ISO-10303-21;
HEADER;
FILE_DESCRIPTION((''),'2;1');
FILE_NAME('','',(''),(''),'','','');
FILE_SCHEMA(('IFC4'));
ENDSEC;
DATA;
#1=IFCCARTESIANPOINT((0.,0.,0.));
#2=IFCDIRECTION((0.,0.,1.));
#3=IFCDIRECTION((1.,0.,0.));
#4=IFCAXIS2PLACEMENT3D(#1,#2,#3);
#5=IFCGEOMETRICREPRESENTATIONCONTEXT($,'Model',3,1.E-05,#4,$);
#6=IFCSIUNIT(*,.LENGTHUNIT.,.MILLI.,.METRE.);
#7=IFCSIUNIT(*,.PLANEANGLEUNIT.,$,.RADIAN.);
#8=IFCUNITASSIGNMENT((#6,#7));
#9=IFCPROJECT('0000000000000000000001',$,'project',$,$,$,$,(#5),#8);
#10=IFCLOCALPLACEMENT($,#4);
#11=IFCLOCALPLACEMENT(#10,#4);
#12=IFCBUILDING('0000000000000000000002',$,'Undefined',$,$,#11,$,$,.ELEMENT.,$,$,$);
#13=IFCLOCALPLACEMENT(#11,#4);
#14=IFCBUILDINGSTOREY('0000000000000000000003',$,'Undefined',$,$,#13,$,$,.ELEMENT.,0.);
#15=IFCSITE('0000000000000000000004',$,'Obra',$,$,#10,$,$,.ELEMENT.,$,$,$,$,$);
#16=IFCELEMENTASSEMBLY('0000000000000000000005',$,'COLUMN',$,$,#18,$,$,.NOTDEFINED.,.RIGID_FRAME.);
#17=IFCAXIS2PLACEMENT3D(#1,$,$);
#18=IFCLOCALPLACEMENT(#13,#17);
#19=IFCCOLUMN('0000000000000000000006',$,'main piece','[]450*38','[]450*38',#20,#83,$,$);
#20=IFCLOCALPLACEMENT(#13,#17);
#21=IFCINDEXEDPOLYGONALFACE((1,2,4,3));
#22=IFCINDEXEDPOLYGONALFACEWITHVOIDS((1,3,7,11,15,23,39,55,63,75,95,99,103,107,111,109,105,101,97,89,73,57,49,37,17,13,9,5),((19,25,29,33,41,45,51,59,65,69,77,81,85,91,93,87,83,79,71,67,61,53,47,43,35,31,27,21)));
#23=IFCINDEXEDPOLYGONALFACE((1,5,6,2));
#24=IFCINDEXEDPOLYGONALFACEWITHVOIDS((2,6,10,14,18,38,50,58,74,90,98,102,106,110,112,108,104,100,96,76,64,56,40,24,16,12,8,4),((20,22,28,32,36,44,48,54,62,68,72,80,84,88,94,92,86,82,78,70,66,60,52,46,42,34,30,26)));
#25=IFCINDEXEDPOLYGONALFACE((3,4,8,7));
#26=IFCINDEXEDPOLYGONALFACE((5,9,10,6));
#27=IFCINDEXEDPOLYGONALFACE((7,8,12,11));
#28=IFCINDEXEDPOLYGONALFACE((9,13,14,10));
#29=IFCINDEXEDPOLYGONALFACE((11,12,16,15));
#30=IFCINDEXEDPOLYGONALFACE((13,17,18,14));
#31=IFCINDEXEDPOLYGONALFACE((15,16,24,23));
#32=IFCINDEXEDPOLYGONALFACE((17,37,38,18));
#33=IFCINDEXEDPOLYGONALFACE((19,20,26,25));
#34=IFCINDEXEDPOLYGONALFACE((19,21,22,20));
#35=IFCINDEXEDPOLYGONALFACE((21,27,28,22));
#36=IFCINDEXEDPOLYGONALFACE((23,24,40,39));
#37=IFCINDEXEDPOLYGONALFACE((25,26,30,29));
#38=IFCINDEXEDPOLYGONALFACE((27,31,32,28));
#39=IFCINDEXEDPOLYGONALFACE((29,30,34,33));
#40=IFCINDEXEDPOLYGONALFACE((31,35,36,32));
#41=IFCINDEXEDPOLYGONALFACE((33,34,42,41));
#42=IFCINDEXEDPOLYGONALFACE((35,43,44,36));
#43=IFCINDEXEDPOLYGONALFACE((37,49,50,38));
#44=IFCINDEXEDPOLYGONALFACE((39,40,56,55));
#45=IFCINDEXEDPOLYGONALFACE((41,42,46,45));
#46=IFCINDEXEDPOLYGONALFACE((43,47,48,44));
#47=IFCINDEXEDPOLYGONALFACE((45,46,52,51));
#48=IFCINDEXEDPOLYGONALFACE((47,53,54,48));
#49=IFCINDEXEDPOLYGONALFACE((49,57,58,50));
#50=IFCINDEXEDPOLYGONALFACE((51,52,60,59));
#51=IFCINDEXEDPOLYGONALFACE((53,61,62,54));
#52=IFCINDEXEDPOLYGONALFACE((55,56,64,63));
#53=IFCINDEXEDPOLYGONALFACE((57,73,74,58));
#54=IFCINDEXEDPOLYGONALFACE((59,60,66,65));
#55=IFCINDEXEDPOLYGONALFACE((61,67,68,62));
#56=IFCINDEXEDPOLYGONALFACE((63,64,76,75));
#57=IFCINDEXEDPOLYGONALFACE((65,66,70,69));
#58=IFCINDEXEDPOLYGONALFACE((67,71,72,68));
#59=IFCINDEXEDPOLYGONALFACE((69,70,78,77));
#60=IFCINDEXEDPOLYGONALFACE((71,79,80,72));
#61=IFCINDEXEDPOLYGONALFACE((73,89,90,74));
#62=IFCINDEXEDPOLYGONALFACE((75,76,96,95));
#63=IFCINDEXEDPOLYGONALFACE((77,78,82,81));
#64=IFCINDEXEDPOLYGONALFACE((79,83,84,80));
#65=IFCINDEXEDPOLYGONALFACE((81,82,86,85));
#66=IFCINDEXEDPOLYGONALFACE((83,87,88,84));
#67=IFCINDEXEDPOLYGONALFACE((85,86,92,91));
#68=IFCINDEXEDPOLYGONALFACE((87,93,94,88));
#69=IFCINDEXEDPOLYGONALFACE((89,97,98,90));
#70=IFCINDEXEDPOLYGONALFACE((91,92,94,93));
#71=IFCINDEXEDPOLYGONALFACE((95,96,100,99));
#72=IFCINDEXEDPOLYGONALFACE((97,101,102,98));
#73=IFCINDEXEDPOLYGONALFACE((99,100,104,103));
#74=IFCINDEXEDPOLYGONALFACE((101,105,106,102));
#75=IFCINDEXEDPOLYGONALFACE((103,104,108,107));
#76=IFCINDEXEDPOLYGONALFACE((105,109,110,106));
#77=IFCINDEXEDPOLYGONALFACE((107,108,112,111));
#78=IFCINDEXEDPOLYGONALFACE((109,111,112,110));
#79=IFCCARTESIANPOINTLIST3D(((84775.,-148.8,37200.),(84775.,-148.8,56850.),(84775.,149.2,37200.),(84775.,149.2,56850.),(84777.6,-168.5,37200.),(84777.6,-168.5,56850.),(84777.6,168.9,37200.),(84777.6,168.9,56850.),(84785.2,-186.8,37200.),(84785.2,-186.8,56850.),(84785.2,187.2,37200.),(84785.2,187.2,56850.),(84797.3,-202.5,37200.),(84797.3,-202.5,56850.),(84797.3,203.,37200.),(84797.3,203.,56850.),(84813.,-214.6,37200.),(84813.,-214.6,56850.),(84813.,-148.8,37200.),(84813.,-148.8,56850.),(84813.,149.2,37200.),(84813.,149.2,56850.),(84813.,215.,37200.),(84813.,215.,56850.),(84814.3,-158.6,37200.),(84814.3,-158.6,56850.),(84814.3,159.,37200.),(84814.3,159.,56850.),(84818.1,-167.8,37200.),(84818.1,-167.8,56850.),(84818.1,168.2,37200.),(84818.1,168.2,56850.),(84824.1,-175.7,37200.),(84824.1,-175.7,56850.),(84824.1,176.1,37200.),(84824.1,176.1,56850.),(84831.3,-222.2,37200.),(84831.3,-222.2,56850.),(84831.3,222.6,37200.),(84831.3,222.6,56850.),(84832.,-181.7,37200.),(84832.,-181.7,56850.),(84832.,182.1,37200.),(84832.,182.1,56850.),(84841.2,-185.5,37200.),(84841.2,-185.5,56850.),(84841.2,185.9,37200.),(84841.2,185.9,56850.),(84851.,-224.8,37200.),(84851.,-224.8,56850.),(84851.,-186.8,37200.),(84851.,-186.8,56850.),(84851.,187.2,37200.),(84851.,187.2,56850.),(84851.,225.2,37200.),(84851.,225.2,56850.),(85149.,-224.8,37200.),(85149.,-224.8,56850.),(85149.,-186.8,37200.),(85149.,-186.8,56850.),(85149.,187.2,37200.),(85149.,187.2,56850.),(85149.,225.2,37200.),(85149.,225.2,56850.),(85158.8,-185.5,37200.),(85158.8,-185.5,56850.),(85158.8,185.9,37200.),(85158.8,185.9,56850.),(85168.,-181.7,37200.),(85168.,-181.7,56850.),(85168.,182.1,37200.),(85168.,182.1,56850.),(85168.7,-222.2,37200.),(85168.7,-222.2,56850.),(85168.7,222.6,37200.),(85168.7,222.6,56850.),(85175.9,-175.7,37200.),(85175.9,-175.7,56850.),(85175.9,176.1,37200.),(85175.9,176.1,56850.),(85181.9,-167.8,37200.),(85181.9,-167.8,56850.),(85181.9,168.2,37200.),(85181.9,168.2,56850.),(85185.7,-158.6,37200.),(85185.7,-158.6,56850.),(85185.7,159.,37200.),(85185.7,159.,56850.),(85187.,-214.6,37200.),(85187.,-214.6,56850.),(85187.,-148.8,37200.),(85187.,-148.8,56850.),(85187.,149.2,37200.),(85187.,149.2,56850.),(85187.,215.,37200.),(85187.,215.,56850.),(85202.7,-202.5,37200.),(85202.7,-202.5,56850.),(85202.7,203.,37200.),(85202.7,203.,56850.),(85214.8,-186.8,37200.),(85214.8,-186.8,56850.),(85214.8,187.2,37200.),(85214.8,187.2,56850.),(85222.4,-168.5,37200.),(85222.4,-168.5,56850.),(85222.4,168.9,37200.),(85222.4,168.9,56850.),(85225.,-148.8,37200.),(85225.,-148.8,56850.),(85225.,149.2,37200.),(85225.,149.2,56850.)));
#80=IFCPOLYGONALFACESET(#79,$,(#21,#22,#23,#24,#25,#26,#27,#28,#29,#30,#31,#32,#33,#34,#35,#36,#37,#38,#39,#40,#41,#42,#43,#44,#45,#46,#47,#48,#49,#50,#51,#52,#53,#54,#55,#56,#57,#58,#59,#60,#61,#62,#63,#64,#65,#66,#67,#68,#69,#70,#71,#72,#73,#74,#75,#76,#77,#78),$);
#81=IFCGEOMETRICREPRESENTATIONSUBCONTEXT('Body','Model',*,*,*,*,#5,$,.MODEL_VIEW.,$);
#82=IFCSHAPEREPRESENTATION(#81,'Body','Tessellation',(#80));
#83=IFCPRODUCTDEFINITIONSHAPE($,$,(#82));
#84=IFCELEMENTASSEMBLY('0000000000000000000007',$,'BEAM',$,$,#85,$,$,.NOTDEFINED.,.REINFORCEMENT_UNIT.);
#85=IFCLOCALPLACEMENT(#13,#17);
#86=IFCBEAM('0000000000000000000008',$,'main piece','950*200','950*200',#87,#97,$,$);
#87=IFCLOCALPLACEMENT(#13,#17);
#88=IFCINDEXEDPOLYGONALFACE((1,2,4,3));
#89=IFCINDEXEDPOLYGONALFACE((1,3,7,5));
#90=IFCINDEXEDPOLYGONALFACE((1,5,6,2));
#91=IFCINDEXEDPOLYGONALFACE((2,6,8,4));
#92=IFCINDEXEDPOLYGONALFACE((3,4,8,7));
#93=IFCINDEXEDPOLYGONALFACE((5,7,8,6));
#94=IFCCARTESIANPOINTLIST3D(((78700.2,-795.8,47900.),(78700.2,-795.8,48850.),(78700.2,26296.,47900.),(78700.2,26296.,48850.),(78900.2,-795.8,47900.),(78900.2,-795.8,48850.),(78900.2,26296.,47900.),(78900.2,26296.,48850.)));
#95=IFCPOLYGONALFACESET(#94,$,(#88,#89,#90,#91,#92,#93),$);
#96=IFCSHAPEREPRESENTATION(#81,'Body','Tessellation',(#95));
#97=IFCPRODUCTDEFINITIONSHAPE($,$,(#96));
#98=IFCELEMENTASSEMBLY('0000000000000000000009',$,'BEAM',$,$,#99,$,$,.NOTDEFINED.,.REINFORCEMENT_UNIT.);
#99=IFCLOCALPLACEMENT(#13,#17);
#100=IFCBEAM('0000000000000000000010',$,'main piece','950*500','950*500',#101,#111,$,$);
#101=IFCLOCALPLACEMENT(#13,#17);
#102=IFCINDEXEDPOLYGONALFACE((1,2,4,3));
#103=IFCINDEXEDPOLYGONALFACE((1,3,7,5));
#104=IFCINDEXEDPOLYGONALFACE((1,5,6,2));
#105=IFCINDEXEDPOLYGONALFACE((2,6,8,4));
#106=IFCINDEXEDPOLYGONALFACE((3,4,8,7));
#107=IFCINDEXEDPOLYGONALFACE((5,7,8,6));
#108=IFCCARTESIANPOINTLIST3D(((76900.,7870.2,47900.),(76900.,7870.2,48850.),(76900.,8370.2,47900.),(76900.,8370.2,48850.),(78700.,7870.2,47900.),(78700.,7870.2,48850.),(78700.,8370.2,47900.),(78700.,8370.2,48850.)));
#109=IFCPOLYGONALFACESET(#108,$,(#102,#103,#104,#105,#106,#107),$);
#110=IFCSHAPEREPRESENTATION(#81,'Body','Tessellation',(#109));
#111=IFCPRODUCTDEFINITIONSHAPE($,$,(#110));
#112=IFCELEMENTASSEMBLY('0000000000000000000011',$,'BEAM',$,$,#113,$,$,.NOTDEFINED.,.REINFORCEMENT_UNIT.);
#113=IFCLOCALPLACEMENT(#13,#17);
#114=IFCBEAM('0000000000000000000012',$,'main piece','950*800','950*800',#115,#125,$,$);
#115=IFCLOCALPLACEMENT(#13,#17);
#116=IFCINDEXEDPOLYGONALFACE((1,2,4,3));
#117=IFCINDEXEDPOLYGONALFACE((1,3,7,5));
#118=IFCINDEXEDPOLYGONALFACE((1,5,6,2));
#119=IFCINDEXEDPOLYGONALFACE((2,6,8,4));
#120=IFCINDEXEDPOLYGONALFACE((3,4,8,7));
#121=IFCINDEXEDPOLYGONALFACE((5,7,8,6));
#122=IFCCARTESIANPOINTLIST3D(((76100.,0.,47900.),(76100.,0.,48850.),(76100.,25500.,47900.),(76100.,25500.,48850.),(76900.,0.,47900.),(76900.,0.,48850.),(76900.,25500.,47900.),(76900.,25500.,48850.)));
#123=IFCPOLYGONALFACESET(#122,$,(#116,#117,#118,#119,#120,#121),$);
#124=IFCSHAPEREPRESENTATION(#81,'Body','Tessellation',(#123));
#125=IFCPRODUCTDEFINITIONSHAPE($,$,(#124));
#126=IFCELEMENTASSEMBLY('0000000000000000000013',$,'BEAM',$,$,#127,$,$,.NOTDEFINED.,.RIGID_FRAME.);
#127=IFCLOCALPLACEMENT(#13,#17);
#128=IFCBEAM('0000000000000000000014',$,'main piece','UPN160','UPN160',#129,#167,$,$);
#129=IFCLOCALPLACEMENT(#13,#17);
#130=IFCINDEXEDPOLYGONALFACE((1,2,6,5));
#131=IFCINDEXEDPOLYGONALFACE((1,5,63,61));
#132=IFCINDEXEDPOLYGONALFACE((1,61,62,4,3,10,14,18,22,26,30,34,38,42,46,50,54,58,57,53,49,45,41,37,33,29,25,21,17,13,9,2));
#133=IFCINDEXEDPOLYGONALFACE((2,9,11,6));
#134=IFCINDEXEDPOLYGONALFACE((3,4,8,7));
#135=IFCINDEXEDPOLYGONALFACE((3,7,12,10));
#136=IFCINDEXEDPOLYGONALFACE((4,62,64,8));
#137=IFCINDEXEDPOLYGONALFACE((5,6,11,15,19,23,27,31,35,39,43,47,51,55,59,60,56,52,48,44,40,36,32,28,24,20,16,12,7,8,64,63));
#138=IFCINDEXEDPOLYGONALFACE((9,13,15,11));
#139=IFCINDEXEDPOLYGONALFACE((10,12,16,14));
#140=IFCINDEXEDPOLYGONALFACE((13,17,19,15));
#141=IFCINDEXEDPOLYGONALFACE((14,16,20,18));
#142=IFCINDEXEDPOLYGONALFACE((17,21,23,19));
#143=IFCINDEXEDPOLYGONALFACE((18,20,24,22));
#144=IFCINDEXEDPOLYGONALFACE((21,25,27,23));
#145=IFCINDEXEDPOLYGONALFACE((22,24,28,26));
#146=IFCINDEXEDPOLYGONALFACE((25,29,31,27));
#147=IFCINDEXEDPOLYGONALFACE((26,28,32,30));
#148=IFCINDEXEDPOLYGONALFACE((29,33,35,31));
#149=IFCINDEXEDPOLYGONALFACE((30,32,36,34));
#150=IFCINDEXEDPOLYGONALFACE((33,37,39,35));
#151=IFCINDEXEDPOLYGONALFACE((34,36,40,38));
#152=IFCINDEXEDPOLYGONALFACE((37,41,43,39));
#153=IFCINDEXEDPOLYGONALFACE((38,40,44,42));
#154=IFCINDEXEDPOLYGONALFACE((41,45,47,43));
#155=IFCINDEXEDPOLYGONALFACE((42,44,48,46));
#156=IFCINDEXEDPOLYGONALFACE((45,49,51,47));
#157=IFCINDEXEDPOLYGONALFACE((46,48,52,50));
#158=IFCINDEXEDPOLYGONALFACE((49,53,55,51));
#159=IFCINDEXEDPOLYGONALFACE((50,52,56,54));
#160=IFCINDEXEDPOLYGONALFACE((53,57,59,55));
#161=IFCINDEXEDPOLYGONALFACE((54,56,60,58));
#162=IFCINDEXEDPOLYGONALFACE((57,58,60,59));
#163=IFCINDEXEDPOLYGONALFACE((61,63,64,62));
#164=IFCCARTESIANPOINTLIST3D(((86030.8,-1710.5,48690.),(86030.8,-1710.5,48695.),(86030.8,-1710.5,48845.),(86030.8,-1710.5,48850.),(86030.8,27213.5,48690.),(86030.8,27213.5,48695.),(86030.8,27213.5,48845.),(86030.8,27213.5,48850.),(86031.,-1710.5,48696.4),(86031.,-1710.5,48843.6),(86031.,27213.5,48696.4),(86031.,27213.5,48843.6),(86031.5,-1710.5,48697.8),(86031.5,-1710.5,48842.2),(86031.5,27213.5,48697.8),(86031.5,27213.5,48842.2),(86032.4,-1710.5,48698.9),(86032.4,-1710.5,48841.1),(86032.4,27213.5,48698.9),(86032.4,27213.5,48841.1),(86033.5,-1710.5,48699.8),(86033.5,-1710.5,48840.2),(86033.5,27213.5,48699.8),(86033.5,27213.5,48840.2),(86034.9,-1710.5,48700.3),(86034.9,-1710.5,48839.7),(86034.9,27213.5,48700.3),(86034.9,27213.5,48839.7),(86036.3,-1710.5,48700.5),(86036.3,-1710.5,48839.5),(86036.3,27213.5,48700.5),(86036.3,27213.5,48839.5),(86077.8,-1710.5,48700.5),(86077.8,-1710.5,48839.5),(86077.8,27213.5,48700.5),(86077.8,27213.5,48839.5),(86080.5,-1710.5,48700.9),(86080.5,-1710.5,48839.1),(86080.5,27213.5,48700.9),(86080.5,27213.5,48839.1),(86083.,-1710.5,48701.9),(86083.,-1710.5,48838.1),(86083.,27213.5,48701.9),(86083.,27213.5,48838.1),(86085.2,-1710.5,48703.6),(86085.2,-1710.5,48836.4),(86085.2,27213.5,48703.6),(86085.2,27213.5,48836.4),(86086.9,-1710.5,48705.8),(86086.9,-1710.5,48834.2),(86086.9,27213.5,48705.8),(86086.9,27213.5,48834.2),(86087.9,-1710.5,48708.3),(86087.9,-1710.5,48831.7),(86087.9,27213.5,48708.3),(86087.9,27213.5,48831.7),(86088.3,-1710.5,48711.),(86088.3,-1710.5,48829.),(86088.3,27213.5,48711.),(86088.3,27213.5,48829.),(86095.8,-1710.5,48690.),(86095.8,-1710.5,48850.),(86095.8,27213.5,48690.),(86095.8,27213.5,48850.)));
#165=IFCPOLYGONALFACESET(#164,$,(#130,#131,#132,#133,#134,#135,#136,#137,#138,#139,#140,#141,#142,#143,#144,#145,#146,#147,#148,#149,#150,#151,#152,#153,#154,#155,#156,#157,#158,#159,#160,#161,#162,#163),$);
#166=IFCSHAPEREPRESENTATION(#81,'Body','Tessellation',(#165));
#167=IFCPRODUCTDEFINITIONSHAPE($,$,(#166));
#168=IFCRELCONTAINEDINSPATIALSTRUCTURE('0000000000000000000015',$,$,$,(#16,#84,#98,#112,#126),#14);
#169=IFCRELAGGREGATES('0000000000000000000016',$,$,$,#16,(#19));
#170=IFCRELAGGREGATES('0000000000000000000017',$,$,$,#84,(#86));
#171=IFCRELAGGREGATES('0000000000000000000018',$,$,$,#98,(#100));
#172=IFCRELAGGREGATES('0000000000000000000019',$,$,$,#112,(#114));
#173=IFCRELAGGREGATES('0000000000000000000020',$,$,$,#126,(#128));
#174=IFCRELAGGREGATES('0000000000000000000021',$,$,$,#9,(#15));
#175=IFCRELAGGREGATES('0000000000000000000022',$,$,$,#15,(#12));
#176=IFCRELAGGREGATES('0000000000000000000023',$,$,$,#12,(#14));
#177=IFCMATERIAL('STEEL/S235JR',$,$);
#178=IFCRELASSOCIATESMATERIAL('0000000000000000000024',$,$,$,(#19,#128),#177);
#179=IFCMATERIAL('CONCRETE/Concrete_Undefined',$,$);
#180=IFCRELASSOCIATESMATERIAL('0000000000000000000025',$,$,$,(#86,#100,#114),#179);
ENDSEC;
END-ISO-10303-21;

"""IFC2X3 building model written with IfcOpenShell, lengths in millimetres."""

from ifc_helpers import new_model, si_unit, frame, origin_with_axes, origin_2d_with_axis, place, context, subcontext, project, spatial, rectangle, hollow_rectangle, u_section, extrude, material, element, aggregate, save


model = new_model("IFC2X3")

# Units and contexts
model_context = context("Model", 3, precision=1e-05, world=origin_with_axes())
body_context = subcontext(model_context, "Body", "Model", "MODEL_VIEW")
ifc_project = project(units=[si_unit("LENGTHUNIT", "METRE", prefix="MILLI"), si_unit("PLANEANGLEUNIT", "RADIAN")], contexts=[model_context])

# Site, building, storey
site_placement = place(None, origin_with_axes())
site = spatial("IfcSite", under=ifc_project, at=site_placement, Name="Obra", CompositionType="ELEMENT")
building_placement = place(site_placement, origin_with_axes())
building = spatial("IfcBuilding", under=site, at=building_placement, Name="Undefined", CompositionType="ELEMENT")
storey_placement = place(building_placement, origin_with_axes())
storey = spatial("IfcBuildingStorey", under=building, at=storey_placement, Name="Undefined", CompositionType="ELEMENT", Elevation=0.0)

# Element assembly, column
ifc_material_1 = material(Name="STEEL/S235JR")
assembly_1_placement = place(storey_placement, origin_with_axes())
assembly_1 = element("IfcElementAssembly", 1, at=assembly_1_placement, inside=storey, Name="COLUMN", AssemblyPlace="NOTDEFINED", PredefinedType="RIGID_FRAME")
column_1_placement = place(assembly_1_placement, frame((85000.0, 0.2, 37200.0), z_axis=(0.0, 0.0, 1.0), x_axis=(0.0, 1.0, 0.0)))
column_1 = element("IfcColumn", 2, at=column_1_placement, material=ifc_material_1, Name="main piece", Description="[]450*38", ObjectType="[]450*38", context=body_context, shape_type="SweptSolid", body=[
    extrude(hollow_rectangle(XDim=450.0, YDim=450.0, WallThickness=38.0, InnerFilletRadius=38.0, OuterFilletRadius=76.0, at=origin_2d_with_axis()), frame((0.0, 0.0, 19650.0), z_axis=(0.0, 0.0, -1.0), x_axis=(0.0, 1.0, 0.0)), (0.0, 0.0, 1.0), 19650.0),
])
aggregate(assembly_1, [column_1])

# Element assemblies, beams
assembly_2_placement = place(storey_placement, origin_with_axes())
assembly_2 = element("IfcElementAssembly", 3, at=assembly_2_placement, inside=storey, Name="BEAM", AssemblyPlace="NOTDEFINED", PredefinedType="REINFORCEMENT_UNIT")
ifc_material_2 = material(Name="CONCRETE/Concrete_Undefined")
beam_1_placement = place(assembly_2_placement, frame((78800.2, -795.8, 48375.0), z_axis=(0.0, 0.0, 1.0), x_axis=(0.0, 1.0, 0.0)))
beam_1 = element("IfcBeam", 4, at=beam_1_placement, material=ifc_material_2, Name="main piece", Description="950*200", ObjectType="950*200", context=body_context, shape_type="SweptSolid", body=[
    extrude(rectangle(XDim=200.0, YDim=950.0, at=origin_2d_with_axis()), frame((27091.8, 0.0, 0.0), z_axis=(-1.0, 0.0, 0.0), x_axis=(0.0, -1.0, 0.0)), (0.0, 0.0, 1.0), 27091.8),
])
aggregate(assembly_2, [beam_1])
assembly_3_placement = place(storey_placement, origin_with_axes())
assembly_3 = element("IfcElementAssembly", 5, at=assembly_3_placement, inside=storey, Name="BEAM", AssemblyPlace="NOTDEFINED", PredefinedType="REINFORCEMENT_UNIT")
beam_2_placement = place(assembly_3_placement, frame((78700.0, 8120.2, 48375.0), z_axis=(0.0, 0.0, 1.0), x_axis=(-1.0, 0.0, 0.0)))
beam_2 = element("IfcBeam", 6, at=beam_2_placement, material=ifc_material_2, Name="main piece", Description="950*500", ObjectType="950*500", context=body_context, shape_type="SweptSolid", body=[
    extrude(rectangle(XDim=500.0, YDim=950.0, at=origin_2d_with_axis()), frame((1800.0, 0.0, 0.0), z_axis=(-1.0, 0.0, 0.0), x_axis=(0.0, -1.0, 0.0)), (0.0, 0.0, 1.0), 1800.0),
])
aggregate(assembly_3, [beam_2])
assembly_4_placement = place(storey_placement, origin_with_axes())
assembly_4 = element("IfcElementAssembly", 7, at=assembly_4_placement, inside=storey, Name="BEAM", AssemblyPlace="NOTDEFINED", PredefinedType="REINFORCEMENT_UNIT")
beam_3_placement = place(assembly_4_placement, frame((76500.0, 0.0, 48375.0), z_axis=(0.0, 0.0, 1.0), x_axis=(0.0, 1.0, 0.0)))
beam_3 = element("IfcBeam", 8, at=beam_3_placement, material=ifc_material_2, Name="main piece", Description="950*800", ObjectType="950*800", context=body_context, shape_type="SweptSolid", body=[
    extrude(rectangle(XDim=800.0, YDim=950.0, at=origin_2d_with_axis()), frame((25500.0, 0.0, 0.0), z_axis=(-1.0, 0.0, 0.0), x_axis=(0.0, -1.0, 0.0)), (0.0, 0.0, 1.0), 25500.0),
])
aggregate(assembly_4, [beam_3])
assembly_5_placement = place(storey_placement, origin_with_axes())
assembly_5 = element("IfcElementAssembly", 9, at=assembly_5_placement, inside=storey, Name="BEAM", AssemblyPlace="NOTDEFINED", PredefinedType="RIGID_FRAME")
beam_4_placement = place(assembly_5_placement, frame((86063.3, -1710.5, 48770.0), z_axis=(0.0, 0.0, -1.0), x_axis=(0.0, 1.0, 0.0)))
beam_4 = element("IfcBeam", 10, at=beam_4_placement, material=ifc_material_1, Name="main piece", Description="UPN160", ObjectType="UPN160", context=body_context, shape_type="SweptSolid", body=[
    extrude(u_section(Depth=160.0, FlangeWidth=65.0, WebThickness=7.5, FlangeThickness=10.5, FilletRadius=10.5, EdgeRadius=5.5, at=origin_2d_with_axis()), frame((28924.0, 0.0, 0.0), z_axis=(-1.0, 0.0, 0.0), x_axis=(0.0, -1.0, 0.0)), (0.0, 0.0, 1.0), 28924.0),
])
aggregate(assembly_5, [beam_4])

save(model, "model.ifc")
